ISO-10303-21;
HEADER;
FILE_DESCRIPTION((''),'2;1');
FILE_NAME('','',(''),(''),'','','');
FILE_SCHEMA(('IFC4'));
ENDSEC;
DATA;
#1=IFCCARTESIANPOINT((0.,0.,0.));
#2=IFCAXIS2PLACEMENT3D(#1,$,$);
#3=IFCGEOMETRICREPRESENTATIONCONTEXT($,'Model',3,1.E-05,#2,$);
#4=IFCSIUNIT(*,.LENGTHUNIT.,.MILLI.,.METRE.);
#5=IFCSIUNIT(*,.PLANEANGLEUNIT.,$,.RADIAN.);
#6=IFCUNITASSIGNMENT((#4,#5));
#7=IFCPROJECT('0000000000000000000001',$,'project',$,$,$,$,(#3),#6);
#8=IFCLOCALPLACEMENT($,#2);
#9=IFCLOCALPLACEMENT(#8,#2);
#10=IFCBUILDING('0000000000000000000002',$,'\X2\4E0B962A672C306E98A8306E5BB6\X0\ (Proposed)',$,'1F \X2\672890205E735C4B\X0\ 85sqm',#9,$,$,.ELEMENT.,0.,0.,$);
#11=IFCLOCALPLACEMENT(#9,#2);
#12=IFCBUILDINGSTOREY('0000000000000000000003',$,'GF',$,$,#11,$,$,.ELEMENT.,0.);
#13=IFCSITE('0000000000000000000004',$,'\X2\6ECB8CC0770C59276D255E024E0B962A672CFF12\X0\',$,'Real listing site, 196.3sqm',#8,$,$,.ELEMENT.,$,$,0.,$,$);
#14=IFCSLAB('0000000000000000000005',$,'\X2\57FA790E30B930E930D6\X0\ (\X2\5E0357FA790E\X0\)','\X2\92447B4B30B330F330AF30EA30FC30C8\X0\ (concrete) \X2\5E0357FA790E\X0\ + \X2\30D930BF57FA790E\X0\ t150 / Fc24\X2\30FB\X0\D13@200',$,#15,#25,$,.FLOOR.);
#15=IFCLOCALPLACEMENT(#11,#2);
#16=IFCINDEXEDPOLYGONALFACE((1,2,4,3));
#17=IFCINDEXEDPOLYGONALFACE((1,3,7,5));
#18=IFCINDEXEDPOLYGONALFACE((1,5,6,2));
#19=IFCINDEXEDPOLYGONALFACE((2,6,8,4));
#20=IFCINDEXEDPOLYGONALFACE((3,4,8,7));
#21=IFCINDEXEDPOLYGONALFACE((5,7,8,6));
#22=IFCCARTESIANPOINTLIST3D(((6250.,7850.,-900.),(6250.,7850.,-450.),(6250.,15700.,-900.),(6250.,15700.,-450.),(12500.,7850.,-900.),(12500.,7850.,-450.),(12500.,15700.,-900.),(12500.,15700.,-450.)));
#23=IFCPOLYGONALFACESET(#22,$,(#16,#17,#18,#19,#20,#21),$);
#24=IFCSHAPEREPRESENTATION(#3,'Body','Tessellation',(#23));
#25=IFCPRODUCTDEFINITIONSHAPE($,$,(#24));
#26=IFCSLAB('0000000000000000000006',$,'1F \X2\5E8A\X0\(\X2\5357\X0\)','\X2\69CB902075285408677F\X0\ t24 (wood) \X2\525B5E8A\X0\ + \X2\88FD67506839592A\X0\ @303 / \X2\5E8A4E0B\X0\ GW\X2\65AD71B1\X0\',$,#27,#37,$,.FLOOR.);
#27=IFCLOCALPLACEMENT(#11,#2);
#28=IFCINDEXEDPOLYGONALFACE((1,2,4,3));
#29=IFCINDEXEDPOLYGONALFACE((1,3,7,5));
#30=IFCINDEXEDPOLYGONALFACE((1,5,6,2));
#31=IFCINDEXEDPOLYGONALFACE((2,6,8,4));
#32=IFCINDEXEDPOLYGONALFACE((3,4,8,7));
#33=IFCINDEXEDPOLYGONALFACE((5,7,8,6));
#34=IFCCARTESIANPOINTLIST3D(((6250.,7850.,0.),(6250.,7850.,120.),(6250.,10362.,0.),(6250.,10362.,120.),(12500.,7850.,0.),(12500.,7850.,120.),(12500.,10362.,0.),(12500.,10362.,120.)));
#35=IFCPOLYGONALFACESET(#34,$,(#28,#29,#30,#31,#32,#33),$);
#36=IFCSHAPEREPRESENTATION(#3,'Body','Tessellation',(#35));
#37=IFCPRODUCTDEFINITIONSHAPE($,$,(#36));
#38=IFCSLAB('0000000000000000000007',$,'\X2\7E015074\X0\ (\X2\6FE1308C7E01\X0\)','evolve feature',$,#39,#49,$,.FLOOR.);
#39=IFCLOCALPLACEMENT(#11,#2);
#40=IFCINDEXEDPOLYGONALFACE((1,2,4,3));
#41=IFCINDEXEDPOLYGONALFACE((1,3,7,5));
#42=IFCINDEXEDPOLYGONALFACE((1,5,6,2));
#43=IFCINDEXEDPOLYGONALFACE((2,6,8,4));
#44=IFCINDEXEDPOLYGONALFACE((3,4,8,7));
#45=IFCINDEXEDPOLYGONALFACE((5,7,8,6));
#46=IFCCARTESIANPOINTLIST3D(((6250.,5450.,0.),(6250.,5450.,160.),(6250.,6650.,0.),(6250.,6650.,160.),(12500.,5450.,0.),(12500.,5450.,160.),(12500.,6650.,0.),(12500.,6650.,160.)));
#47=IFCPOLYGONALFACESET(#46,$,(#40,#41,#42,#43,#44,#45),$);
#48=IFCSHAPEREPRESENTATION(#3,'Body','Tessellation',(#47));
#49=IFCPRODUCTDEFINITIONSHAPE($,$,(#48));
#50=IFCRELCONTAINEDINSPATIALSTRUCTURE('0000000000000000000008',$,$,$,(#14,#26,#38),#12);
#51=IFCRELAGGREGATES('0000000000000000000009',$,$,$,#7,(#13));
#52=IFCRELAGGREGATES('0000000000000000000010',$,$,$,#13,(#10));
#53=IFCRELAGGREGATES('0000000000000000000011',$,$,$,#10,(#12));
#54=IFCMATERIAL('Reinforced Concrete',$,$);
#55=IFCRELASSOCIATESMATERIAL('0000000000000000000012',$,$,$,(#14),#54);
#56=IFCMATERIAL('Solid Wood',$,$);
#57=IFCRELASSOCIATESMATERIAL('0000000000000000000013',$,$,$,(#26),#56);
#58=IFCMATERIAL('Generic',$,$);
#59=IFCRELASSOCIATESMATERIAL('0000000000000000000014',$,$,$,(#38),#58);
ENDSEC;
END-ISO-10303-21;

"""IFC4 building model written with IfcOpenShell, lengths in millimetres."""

from ifc_helpers import new_model, si_unit, frame, frame_2d, origin, place, context, project, spatial, rectangle, extrude, material, element, save


model = new_model("IFC4")

# Units and contexts
model_context = context("Model", 3, precision=1e-05, world=origin())
ifc_project = project(units=[si_unit("LENGTHUNIT", "METRE", prefix="MILLI"), si_unit("PLANEANGLEUNIT", "RADIAN")], contexts=[model_context])

# Site, building, storey
site_placement = place(None, origin())
site = spatial("IfcSite", under=ifc_project, at=site_placement, Name="滋賀県大津市下阪本２", ObjectType="Real listing site, 196.3sqm", CompositionType="ELEMENT", RefElevation=0.0)
building_placement = place(site_placement, origin())
building = spatial("IfcBuilding", under=site, at=building_placement, Name="下阪本の風の家 (Proposed)", ObjectType="1F 木造平屋 85sqm", CompositionType="ELEMENT", ElevationOfRefHeight=0.0, ElevationOfTerrain=0.0)
storey_placement = place(building_placement, origin())
storey = spatial("IfcBuildingStorey", under=building, at=storey_placement, Name="GF", CompositionType="ELEMENT", Elevation=0.0)

# Slabs
ifc_material_1 = material(Name="Reinforced Concrete")
slab_1_placement = place(storey_placement, frame((3125.0, 3925.0, -450.0)))
element("IfcSlab", 1, at=slab_1_placement, inside=storey, material=ifc_material_1, Name="基礎スラブ (布基礎)", Description="鉄筋コンクリート (concrete) 布基礎 + ベタ基礎 t150 / Fc24・D13@200", PredefinedType="FLOOR", context=model_context, shape_type="SweptSolid", body=[
    extrude(rectangle(XDim=6250.0, YDim=7850.0, at=frame_2d((3125.0, 3925.0))), frame((3125.0, 3925.0, -450.0)), (0.0, 0.0, 1.0), 450.0),
])
ifc_material_2 = material(Name="Solid Wood")
slab_2_placement = place(storey_placement, frame((3125.0, 3925.0, 0.0)))
element("IfcSlab", 2, at=slab_2_placement, inside=storey, material=ifc_material_2, Name="1F 床(南)", Description="構造用合板 t24 (wood) 剛床 + 製材根太 @303 / 床下 GW断熱", PredefinedType="FLOOR", context=model_context, shape_type="SweptSolid", body=[
    extrude(rectangle(XDim=6250.0, YDim=2512.0, at=frame_2d((3125.0, 1256.0))), frame((3125.0, 3925.0, 0.0)), (0.0, 0.0, 1.0), 120.0),
])
ifc_material_3 = material(Name="Generic")
slab_3_placement = place(storey_placement, frame((3125.0, 2725.0, 0.0)))
element("IfcSlab", 3, at=slab_3_placement, inside=storey, material=ifc_material_3, Name="縁側 (濡れ縁)", Description="evolve feature", PredefinedType="FLOOR", context=model_context, shape_type="SweptSolid", body=[
    extrude(rectangle(XDim=6250.0, YDim=1200.0, at=frame_2d((3125.0, 600.0))), frame((3125.0, 2725.0, 0.0)), (0.0, 0.0, 1.0), 160.0),
])

save(model, "model.ifc")
